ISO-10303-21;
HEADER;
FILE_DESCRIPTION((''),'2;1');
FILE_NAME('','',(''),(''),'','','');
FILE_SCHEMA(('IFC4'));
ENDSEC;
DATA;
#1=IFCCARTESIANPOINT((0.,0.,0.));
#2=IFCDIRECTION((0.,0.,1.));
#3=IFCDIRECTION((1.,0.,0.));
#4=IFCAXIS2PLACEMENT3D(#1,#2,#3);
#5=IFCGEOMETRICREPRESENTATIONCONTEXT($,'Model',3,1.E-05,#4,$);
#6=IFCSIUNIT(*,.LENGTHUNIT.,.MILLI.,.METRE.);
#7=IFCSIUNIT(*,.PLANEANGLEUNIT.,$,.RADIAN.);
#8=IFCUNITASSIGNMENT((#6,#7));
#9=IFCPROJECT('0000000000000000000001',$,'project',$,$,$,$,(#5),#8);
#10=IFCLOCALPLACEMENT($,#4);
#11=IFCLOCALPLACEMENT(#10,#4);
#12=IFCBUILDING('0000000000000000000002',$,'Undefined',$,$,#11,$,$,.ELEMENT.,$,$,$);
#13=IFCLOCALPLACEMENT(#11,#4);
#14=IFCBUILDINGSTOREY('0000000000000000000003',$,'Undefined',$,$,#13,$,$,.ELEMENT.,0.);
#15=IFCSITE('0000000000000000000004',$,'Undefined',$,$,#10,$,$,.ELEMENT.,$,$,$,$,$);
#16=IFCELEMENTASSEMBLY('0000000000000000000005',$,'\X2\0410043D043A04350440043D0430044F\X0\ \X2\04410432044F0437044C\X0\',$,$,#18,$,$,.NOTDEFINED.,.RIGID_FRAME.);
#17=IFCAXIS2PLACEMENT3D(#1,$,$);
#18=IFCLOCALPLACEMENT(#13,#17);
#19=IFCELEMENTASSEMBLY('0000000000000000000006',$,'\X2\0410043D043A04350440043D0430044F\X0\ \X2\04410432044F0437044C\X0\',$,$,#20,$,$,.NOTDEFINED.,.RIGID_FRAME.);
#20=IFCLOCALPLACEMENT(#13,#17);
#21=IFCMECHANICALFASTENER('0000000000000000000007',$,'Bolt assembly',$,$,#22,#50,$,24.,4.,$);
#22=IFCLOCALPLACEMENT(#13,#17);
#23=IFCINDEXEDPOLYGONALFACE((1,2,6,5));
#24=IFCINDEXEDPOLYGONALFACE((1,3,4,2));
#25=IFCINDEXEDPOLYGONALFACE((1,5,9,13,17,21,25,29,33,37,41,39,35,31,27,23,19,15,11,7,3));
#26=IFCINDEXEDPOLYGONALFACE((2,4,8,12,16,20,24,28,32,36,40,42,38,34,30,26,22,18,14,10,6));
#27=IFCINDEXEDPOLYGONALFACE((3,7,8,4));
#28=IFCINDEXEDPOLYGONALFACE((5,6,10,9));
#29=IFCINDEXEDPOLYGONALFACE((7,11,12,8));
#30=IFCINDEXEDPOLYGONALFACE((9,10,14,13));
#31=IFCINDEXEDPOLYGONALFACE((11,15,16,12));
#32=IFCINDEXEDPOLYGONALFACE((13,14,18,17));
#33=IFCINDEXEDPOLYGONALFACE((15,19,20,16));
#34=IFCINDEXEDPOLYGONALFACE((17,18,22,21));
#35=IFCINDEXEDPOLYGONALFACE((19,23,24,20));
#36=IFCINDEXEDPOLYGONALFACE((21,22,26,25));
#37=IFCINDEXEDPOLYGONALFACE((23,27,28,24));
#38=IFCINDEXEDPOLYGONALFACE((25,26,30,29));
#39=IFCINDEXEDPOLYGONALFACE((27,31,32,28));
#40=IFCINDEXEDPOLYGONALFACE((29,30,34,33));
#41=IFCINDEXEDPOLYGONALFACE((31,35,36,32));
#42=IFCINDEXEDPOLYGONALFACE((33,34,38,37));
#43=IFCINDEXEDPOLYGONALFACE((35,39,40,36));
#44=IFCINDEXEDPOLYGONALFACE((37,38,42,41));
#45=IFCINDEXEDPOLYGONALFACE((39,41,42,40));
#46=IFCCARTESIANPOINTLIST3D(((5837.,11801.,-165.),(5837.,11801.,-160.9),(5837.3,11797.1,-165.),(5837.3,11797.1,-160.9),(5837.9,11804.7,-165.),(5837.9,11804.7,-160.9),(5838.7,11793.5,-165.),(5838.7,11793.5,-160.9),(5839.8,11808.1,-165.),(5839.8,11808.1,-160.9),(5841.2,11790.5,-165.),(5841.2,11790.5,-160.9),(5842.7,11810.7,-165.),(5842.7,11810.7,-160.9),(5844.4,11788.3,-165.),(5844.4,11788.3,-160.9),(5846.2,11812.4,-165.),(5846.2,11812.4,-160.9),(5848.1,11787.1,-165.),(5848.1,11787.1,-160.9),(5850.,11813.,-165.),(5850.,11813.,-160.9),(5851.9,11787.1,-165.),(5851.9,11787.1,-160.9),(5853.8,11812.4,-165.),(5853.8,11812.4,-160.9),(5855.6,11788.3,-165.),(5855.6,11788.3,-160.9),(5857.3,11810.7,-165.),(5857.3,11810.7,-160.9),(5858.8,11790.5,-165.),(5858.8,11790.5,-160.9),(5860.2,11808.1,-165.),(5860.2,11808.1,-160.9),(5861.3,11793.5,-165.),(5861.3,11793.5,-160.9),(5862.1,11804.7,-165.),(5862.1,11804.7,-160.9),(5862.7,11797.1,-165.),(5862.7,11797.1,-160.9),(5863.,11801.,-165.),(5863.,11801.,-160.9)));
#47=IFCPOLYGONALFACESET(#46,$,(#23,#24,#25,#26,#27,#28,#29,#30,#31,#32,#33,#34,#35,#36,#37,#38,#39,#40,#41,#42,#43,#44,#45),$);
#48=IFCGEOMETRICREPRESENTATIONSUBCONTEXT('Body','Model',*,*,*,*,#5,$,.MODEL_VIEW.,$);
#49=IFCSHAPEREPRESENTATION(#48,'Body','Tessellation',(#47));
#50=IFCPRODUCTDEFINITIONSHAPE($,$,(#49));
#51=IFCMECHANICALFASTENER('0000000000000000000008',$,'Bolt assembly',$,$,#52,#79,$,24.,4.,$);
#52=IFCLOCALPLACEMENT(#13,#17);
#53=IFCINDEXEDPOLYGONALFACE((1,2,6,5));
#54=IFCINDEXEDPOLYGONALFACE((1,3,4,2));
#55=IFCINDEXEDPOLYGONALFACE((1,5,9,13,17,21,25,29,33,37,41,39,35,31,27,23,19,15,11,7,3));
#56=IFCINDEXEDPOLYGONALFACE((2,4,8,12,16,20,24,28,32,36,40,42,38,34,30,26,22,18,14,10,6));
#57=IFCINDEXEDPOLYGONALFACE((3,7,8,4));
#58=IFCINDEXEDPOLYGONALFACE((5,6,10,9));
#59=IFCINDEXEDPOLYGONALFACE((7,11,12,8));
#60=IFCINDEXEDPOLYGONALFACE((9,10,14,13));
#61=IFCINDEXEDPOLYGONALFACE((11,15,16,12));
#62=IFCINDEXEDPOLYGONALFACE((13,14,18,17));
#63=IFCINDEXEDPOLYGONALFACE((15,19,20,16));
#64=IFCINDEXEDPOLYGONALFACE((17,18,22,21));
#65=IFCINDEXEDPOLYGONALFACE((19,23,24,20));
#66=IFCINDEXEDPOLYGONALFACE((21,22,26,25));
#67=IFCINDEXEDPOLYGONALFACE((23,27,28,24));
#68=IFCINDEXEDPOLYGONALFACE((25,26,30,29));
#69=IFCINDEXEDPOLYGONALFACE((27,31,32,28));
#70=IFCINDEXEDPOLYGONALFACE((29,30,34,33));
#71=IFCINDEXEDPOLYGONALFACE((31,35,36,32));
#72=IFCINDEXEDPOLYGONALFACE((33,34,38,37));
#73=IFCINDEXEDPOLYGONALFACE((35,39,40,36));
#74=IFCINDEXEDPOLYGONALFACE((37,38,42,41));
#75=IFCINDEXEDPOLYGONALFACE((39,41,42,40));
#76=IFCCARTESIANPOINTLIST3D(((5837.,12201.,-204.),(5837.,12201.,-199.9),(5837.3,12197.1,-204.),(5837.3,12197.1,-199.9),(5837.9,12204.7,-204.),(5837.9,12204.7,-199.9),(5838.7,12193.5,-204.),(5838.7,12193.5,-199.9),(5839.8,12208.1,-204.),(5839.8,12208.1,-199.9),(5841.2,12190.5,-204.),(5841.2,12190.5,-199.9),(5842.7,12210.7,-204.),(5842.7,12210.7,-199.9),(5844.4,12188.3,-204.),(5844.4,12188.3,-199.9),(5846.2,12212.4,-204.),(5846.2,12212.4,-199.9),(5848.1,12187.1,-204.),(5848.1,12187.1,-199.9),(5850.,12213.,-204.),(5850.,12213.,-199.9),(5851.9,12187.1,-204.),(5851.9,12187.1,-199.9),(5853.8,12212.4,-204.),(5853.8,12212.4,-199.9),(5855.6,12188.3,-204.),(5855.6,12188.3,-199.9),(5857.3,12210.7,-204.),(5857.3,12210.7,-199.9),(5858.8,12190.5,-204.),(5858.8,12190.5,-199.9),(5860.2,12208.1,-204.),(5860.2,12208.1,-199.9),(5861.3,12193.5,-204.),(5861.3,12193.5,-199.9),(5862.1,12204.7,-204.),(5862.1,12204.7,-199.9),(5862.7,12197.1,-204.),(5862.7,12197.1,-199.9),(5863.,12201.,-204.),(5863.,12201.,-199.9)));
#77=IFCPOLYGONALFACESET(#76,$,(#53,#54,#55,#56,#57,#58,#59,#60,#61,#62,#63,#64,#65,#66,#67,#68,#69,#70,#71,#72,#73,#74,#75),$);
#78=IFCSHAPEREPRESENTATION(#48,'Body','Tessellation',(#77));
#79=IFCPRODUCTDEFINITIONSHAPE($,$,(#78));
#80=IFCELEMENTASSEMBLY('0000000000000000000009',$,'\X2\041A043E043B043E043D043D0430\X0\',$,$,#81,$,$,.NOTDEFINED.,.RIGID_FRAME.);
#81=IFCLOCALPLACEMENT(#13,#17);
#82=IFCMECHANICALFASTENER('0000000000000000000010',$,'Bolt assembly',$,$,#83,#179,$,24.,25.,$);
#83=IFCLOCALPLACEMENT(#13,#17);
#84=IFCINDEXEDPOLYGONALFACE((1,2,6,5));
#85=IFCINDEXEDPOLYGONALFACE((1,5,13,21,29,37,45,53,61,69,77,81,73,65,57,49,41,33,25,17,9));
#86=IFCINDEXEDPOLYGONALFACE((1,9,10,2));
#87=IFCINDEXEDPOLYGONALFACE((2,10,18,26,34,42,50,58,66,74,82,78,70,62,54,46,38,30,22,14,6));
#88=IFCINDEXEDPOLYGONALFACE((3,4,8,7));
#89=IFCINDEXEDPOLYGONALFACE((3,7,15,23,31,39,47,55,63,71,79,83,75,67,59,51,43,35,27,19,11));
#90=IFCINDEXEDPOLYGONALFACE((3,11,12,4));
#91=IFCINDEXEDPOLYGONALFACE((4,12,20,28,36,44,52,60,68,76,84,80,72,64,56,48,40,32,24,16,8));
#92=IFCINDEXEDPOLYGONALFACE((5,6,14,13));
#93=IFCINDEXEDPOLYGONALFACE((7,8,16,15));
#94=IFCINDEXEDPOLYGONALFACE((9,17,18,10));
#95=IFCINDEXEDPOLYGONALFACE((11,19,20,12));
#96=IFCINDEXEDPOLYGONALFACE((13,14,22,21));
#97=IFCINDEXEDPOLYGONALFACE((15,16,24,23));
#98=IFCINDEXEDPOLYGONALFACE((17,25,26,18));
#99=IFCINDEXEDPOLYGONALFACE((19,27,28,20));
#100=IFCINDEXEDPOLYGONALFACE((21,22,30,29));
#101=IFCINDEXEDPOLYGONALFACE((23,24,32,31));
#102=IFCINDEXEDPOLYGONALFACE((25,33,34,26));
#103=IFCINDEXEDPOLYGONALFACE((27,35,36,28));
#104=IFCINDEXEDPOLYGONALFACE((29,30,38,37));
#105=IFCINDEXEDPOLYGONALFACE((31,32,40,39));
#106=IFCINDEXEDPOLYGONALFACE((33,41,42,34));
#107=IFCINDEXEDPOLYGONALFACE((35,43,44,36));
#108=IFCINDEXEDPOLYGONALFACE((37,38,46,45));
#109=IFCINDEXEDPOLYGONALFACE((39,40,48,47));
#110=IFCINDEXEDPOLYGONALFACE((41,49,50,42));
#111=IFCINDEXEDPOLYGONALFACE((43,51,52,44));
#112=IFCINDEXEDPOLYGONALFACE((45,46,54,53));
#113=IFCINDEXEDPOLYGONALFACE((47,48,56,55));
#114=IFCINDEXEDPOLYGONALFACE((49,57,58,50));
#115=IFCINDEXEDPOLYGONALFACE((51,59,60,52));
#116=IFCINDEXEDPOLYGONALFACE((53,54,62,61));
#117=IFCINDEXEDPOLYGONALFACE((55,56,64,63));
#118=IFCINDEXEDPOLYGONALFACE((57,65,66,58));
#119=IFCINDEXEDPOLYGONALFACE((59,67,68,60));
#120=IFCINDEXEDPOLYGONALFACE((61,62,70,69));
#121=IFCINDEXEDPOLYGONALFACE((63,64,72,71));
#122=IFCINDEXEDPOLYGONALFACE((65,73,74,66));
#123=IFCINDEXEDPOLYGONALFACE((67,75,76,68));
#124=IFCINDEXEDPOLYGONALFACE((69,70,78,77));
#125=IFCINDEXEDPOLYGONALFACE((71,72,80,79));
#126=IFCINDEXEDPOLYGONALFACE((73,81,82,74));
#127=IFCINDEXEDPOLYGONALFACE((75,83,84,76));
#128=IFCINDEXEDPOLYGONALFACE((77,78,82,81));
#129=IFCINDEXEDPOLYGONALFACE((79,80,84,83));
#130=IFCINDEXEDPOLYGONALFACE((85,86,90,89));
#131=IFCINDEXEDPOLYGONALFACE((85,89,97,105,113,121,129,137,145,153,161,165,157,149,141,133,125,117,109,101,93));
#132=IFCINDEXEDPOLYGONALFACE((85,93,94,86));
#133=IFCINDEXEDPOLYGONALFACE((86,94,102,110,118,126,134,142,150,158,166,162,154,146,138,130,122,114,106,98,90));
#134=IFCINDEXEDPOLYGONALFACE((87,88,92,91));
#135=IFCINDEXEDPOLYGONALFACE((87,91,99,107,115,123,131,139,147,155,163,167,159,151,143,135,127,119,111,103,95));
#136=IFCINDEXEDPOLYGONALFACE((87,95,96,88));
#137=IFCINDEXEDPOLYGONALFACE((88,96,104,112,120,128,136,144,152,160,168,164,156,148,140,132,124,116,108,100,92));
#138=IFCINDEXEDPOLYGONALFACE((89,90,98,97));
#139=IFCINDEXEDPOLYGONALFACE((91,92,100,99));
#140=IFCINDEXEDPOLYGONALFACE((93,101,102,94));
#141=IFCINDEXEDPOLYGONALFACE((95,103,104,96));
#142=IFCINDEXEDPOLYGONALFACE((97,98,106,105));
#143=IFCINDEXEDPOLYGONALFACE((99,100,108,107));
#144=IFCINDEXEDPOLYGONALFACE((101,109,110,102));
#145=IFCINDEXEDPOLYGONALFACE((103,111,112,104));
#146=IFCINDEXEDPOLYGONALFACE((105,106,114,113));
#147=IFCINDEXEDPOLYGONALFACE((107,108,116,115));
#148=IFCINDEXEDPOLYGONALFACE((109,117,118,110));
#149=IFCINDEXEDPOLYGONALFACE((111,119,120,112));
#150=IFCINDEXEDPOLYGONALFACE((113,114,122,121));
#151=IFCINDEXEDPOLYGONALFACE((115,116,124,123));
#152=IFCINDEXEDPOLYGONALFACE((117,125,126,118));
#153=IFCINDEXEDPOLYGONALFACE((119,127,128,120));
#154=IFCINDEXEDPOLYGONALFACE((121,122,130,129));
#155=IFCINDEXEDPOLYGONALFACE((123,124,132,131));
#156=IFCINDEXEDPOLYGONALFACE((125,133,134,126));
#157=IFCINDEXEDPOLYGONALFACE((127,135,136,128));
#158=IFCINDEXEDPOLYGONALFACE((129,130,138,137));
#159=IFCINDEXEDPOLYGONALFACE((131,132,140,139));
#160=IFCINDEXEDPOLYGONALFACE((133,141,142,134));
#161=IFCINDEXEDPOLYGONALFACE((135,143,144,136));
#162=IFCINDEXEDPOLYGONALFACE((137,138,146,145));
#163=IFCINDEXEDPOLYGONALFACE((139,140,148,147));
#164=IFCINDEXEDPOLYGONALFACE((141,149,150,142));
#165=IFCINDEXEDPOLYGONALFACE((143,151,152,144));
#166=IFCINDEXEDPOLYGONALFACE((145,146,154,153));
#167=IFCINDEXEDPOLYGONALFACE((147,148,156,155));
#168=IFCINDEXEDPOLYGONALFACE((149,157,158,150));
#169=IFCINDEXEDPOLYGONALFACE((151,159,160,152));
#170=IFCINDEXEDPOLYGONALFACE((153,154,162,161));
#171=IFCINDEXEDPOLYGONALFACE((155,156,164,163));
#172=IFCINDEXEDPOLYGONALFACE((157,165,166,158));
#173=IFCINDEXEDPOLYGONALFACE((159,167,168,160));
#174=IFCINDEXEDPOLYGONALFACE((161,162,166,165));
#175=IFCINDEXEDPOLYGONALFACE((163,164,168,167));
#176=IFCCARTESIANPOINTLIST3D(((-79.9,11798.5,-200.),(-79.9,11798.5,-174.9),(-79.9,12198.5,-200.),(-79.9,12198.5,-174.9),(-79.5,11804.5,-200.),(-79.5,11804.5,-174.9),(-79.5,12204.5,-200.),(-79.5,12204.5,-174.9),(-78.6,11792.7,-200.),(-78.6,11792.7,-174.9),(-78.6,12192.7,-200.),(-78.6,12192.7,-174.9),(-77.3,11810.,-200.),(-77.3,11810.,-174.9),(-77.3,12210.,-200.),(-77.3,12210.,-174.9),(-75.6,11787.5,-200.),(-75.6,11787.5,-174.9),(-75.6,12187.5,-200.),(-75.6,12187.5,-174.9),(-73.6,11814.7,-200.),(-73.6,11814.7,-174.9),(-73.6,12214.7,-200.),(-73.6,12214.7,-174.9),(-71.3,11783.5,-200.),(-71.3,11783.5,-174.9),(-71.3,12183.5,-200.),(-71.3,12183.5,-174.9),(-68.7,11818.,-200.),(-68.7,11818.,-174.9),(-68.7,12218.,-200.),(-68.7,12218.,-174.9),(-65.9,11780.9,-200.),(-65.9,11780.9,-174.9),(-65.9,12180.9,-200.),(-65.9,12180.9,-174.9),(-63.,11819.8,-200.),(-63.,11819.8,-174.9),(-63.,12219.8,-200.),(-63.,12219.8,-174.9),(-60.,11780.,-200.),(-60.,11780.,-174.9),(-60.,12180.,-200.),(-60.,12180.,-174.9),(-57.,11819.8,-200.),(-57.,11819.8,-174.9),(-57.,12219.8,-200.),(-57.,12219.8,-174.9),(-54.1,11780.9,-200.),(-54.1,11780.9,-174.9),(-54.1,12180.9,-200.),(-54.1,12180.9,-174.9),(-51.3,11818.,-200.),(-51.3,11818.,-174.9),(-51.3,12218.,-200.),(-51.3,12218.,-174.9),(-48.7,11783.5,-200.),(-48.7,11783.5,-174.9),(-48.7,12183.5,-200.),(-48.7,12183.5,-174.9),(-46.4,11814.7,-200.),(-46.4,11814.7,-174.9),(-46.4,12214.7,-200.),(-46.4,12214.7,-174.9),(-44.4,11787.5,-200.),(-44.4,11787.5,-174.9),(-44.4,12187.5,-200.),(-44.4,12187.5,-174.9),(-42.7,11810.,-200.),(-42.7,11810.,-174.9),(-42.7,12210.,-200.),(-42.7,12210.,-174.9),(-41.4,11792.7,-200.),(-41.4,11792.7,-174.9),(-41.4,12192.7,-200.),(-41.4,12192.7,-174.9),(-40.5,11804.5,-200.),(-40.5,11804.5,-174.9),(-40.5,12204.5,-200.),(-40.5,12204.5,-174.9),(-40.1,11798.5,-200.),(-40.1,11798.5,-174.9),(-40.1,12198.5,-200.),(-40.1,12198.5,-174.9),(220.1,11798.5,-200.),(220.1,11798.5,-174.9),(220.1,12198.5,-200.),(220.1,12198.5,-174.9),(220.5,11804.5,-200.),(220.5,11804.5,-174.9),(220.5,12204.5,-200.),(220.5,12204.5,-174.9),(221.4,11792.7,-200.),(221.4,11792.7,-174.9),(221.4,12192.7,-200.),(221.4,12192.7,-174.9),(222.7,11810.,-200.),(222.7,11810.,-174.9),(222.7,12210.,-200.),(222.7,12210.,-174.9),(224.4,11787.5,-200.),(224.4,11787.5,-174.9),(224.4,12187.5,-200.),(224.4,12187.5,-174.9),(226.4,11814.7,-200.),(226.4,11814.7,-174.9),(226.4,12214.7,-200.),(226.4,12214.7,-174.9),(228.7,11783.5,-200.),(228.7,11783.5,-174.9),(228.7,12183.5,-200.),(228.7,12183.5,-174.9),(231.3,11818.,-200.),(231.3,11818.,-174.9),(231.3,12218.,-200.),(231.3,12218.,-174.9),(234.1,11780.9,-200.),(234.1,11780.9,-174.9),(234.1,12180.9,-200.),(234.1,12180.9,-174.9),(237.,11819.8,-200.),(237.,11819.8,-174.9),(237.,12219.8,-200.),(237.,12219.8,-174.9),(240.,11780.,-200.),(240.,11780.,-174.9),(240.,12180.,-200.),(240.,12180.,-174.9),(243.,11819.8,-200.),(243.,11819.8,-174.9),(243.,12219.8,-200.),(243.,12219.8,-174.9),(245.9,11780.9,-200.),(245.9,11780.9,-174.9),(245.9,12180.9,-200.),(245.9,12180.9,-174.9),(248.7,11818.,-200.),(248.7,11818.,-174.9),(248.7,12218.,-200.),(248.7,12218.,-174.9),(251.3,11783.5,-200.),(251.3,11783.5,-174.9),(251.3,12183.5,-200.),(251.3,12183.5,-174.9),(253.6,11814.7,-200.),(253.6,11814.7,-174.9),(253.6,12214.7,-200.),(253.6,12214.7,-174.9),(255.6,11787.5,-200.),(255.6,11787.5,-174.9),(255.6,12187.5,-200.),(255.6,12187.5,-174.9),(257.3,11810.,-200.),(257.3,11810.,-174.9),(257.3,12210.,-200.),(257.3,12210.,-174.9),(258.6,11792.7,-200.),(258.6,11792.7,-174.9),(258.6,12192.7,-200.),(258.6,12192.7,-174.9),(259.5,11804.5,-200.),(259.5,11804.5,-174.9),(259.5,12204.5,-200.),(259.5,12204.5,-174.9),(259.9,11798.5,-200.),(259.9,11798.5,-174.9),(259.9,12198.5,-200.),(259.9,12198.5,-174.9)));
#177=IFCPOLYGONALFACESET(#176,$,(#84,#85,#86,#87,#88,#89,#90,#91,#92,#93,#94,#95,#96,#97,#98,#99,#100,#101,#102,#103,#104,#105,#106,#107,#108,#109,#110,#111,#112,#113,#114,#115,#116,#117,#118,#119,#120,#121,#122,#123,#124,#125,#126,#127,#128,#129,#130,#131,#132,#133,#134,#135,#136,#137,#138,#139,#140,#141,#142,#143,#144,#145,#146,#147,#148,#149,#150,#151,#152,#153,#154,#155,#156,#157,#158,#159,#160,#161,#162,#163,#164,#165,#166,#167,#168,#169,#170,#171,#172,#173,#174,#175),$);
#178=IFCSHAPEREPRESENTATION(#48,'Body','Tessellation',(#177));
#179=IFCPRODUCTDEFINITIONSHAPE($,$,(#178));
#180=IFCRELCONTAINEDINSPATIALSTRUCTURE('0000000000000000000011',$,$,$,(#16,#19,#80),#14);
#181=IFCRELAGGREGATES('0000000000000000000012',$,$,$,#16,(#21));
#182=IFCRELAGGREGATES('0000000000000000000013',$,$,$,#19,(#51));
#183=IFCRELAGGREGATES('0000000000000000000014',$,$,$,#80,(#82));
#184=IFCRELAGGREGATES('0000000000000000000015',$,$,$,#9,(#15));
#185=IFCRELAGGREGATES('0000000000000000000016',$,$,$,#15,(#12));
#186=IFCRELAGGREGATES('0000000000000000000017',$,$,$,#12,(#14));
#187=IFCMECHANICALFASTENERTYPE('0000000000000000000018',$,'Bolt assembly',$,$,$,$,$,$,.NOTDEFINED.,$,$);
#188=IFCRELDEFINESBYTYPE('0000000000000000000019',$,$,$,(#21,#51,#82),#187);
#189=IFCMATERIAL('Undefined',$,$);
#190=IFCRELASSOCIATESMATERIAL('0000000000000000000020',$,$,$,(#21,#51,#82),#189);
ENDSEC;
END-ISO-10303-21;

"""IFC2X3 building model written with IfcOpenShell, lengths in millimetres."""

from ifc_helpers import new_model, si_unit, frame, origin_with_axes, origin_2d_with_axis, place, context, subcontext, project, spatial, circle, extrude, source, transform, mapped, material, type_object, element, aggregate, save


model = new_model("IFC2X3")

# Units and contexts
model_context = context("Model", 3, precision=1e-05, world=origin_with_axes())
body_context = subcontext(model_context, "Body", "Model", "MODEL_VIEW")
ifc_project = project(units=[si_unit("LENGTHUNIT", "METRE", prefix="MILLI"), si_unit("PLANEANGLEUNIT", "RADIAN")], contexts=[model_context])

# Site, building, storey
site_placement = place(None, origin_with_axes())
site = spatial("IfcSite", under=ifc_project, at=site_placement, Name="Undefined", CompositionType="ELEMENT")
building_placement = place(site_placement, origin_with_axes())
building = spatial("IfcBuilding", under=site, at=building_placement, Name="Undefined", CompositionType="ELEMENT")
storey_placement = place(building_placement, origin_with_axes())
storey = spatial("IfcBuildingStorey", under=building, at=storey_placement, Name="Undefined", CompositionType="ELEMENT", Elevation=0.0)

# Element assemblies
assembly_1_placement = place(storey_placement, origin_with_axes())
assembly_1 = element("IfcElementAssembly", 1, at=assembly_1_placement, inside=storey, Name="Анкерная связь", AssemblyPlace="NOTDEFINED", PredefinedType="RIGID_FRAME")
assembly_2_placement = place(storey_placement, origin_with_axes())
assembly_2 = element("IfcElementAssembly", 2, at=assembly_2_placement, inside=storey, Name="Анкерная связь", AssemblyPlace="NOTDEFINED", PredefinedType="RIGID_FRAME")

# Mechanical fasteners
ifc_material_1 = material(Name="Undefined")
mechanical_fastener_type = type_object("IfcMechanicalFastenerType", Name="Bolt assembly")
shared_shape_1 = source(origin_with_axes(), body_context, "Body", "SweptSolid", [
    extrude(circle(Radius=13.0, at=origin_2d_with_axis()), frame((0.0, -4.0, 0.0), z_axis=(0.0, 1.0, 0.0), x_axis=(1.0, 0.0, 0.0)), (0.0, 0.0, 1.0), 4.1),
])
mechanical_fastener_1_placement = place(assembly_1_placement, frame((5850.0, 11800.0, -161.0), z_axis=(1.0, 0.0, 0.0), x_axis=(0.0, 1.0, 0.0)))
mechanical_fastener_1 = element("IfcMechanicalFastener", 3, at=mechanical_fastener_1_placement, type_object=mechanical_fastener_type, material=ifc_material_1, Name="Bolt assembly", NominalDiameter=24.0, NominalLength=4.0, context=body_context, shape_type="MappedRepresentation", body=[
    mapped(shared_shape_1, transform((0.0, 0.0, 0.0))),
])
aggregate(assembly_1, [mechanical_fastener_1])
mechanical_fastener_2_placement = place(assembly_2_placement, frame((5850.0, 12200.0, -200.0), z_axis=(1.0, 0.0, 0.0), x_axis=(0.0, 1.0, 0.0)))
mechanical_fastener_2 = element("IfcMechanicalFastener", 4, at=mechanical_fastener_2_placement, type_object=mechanical_fastener_type, material=ifc_material_1, Name="Bolt assembly", NominalDiameter=24.0, NominalLength=4.0, context=body_context, shape_type="MappedRepresentation", body=[
    mapped(shared_shape_1, transform((0.0, 0.0, 0.0))),
])
aggregate(assembly_2, [mechanical_fastener_2])

# Element assembly, mechanical fastener
assembly_3_placement = place(storey_placement, origin_with_axes())
assembly_3 = element("IfcElementAssembly", 5, at=assembly_3_placement, inside=storey, Name="Колонна", AssemblyPlace="NOTDEFINED", PredefinedType="RIGID_FRAME")
shared_shape_2 = source(origin_with_axes(), body_context, "Body", "SweptSolid", [
    extrude(circle(Radius=20.0, at=origin_2d_with_axis()), frame((0.0, -25.0, 0.0), z_axis=(0.0, 1.0, 0.0), x_axis=(1.0, 0.0, 0.0)), (0.0, 0.0, 1.0), 25.1),
])
mechanical_fastener_3_placement = place(assembly_3_placement, frame((90.0, 12122.0, -175.0), z_axis=(-1.0, 0.0, 0.0), x_axis=(0.0, -1.0, 0.0)))
mechanical_fastener_3 = element("IfcMechanicalFastener", 6, at=mechanical_fastener_3_placement, type_object=mechanical_fastener_type, material=ifc_material_1, Name="Bolt assembly", NominalDiameter=24.0, NominalLength=25.0, context=body_context, shape_type="MappedRepresentation", body=[
    mapped(shared_shape_2, transform((-78.0, 0.0, -150.0))),
    mapped(shared_shape_2, transform((-78.0, 0.0, 150.0))),
    mapped(shared_shape_2, transform((322.0, 0.0, -150.0))),
    mapped(shared_shape_2, transform((322.0, 0.0, 150.0))),
])
aggregate(assembly_3, [mechanical_fastener_3])

save(model, "model.ifc")
